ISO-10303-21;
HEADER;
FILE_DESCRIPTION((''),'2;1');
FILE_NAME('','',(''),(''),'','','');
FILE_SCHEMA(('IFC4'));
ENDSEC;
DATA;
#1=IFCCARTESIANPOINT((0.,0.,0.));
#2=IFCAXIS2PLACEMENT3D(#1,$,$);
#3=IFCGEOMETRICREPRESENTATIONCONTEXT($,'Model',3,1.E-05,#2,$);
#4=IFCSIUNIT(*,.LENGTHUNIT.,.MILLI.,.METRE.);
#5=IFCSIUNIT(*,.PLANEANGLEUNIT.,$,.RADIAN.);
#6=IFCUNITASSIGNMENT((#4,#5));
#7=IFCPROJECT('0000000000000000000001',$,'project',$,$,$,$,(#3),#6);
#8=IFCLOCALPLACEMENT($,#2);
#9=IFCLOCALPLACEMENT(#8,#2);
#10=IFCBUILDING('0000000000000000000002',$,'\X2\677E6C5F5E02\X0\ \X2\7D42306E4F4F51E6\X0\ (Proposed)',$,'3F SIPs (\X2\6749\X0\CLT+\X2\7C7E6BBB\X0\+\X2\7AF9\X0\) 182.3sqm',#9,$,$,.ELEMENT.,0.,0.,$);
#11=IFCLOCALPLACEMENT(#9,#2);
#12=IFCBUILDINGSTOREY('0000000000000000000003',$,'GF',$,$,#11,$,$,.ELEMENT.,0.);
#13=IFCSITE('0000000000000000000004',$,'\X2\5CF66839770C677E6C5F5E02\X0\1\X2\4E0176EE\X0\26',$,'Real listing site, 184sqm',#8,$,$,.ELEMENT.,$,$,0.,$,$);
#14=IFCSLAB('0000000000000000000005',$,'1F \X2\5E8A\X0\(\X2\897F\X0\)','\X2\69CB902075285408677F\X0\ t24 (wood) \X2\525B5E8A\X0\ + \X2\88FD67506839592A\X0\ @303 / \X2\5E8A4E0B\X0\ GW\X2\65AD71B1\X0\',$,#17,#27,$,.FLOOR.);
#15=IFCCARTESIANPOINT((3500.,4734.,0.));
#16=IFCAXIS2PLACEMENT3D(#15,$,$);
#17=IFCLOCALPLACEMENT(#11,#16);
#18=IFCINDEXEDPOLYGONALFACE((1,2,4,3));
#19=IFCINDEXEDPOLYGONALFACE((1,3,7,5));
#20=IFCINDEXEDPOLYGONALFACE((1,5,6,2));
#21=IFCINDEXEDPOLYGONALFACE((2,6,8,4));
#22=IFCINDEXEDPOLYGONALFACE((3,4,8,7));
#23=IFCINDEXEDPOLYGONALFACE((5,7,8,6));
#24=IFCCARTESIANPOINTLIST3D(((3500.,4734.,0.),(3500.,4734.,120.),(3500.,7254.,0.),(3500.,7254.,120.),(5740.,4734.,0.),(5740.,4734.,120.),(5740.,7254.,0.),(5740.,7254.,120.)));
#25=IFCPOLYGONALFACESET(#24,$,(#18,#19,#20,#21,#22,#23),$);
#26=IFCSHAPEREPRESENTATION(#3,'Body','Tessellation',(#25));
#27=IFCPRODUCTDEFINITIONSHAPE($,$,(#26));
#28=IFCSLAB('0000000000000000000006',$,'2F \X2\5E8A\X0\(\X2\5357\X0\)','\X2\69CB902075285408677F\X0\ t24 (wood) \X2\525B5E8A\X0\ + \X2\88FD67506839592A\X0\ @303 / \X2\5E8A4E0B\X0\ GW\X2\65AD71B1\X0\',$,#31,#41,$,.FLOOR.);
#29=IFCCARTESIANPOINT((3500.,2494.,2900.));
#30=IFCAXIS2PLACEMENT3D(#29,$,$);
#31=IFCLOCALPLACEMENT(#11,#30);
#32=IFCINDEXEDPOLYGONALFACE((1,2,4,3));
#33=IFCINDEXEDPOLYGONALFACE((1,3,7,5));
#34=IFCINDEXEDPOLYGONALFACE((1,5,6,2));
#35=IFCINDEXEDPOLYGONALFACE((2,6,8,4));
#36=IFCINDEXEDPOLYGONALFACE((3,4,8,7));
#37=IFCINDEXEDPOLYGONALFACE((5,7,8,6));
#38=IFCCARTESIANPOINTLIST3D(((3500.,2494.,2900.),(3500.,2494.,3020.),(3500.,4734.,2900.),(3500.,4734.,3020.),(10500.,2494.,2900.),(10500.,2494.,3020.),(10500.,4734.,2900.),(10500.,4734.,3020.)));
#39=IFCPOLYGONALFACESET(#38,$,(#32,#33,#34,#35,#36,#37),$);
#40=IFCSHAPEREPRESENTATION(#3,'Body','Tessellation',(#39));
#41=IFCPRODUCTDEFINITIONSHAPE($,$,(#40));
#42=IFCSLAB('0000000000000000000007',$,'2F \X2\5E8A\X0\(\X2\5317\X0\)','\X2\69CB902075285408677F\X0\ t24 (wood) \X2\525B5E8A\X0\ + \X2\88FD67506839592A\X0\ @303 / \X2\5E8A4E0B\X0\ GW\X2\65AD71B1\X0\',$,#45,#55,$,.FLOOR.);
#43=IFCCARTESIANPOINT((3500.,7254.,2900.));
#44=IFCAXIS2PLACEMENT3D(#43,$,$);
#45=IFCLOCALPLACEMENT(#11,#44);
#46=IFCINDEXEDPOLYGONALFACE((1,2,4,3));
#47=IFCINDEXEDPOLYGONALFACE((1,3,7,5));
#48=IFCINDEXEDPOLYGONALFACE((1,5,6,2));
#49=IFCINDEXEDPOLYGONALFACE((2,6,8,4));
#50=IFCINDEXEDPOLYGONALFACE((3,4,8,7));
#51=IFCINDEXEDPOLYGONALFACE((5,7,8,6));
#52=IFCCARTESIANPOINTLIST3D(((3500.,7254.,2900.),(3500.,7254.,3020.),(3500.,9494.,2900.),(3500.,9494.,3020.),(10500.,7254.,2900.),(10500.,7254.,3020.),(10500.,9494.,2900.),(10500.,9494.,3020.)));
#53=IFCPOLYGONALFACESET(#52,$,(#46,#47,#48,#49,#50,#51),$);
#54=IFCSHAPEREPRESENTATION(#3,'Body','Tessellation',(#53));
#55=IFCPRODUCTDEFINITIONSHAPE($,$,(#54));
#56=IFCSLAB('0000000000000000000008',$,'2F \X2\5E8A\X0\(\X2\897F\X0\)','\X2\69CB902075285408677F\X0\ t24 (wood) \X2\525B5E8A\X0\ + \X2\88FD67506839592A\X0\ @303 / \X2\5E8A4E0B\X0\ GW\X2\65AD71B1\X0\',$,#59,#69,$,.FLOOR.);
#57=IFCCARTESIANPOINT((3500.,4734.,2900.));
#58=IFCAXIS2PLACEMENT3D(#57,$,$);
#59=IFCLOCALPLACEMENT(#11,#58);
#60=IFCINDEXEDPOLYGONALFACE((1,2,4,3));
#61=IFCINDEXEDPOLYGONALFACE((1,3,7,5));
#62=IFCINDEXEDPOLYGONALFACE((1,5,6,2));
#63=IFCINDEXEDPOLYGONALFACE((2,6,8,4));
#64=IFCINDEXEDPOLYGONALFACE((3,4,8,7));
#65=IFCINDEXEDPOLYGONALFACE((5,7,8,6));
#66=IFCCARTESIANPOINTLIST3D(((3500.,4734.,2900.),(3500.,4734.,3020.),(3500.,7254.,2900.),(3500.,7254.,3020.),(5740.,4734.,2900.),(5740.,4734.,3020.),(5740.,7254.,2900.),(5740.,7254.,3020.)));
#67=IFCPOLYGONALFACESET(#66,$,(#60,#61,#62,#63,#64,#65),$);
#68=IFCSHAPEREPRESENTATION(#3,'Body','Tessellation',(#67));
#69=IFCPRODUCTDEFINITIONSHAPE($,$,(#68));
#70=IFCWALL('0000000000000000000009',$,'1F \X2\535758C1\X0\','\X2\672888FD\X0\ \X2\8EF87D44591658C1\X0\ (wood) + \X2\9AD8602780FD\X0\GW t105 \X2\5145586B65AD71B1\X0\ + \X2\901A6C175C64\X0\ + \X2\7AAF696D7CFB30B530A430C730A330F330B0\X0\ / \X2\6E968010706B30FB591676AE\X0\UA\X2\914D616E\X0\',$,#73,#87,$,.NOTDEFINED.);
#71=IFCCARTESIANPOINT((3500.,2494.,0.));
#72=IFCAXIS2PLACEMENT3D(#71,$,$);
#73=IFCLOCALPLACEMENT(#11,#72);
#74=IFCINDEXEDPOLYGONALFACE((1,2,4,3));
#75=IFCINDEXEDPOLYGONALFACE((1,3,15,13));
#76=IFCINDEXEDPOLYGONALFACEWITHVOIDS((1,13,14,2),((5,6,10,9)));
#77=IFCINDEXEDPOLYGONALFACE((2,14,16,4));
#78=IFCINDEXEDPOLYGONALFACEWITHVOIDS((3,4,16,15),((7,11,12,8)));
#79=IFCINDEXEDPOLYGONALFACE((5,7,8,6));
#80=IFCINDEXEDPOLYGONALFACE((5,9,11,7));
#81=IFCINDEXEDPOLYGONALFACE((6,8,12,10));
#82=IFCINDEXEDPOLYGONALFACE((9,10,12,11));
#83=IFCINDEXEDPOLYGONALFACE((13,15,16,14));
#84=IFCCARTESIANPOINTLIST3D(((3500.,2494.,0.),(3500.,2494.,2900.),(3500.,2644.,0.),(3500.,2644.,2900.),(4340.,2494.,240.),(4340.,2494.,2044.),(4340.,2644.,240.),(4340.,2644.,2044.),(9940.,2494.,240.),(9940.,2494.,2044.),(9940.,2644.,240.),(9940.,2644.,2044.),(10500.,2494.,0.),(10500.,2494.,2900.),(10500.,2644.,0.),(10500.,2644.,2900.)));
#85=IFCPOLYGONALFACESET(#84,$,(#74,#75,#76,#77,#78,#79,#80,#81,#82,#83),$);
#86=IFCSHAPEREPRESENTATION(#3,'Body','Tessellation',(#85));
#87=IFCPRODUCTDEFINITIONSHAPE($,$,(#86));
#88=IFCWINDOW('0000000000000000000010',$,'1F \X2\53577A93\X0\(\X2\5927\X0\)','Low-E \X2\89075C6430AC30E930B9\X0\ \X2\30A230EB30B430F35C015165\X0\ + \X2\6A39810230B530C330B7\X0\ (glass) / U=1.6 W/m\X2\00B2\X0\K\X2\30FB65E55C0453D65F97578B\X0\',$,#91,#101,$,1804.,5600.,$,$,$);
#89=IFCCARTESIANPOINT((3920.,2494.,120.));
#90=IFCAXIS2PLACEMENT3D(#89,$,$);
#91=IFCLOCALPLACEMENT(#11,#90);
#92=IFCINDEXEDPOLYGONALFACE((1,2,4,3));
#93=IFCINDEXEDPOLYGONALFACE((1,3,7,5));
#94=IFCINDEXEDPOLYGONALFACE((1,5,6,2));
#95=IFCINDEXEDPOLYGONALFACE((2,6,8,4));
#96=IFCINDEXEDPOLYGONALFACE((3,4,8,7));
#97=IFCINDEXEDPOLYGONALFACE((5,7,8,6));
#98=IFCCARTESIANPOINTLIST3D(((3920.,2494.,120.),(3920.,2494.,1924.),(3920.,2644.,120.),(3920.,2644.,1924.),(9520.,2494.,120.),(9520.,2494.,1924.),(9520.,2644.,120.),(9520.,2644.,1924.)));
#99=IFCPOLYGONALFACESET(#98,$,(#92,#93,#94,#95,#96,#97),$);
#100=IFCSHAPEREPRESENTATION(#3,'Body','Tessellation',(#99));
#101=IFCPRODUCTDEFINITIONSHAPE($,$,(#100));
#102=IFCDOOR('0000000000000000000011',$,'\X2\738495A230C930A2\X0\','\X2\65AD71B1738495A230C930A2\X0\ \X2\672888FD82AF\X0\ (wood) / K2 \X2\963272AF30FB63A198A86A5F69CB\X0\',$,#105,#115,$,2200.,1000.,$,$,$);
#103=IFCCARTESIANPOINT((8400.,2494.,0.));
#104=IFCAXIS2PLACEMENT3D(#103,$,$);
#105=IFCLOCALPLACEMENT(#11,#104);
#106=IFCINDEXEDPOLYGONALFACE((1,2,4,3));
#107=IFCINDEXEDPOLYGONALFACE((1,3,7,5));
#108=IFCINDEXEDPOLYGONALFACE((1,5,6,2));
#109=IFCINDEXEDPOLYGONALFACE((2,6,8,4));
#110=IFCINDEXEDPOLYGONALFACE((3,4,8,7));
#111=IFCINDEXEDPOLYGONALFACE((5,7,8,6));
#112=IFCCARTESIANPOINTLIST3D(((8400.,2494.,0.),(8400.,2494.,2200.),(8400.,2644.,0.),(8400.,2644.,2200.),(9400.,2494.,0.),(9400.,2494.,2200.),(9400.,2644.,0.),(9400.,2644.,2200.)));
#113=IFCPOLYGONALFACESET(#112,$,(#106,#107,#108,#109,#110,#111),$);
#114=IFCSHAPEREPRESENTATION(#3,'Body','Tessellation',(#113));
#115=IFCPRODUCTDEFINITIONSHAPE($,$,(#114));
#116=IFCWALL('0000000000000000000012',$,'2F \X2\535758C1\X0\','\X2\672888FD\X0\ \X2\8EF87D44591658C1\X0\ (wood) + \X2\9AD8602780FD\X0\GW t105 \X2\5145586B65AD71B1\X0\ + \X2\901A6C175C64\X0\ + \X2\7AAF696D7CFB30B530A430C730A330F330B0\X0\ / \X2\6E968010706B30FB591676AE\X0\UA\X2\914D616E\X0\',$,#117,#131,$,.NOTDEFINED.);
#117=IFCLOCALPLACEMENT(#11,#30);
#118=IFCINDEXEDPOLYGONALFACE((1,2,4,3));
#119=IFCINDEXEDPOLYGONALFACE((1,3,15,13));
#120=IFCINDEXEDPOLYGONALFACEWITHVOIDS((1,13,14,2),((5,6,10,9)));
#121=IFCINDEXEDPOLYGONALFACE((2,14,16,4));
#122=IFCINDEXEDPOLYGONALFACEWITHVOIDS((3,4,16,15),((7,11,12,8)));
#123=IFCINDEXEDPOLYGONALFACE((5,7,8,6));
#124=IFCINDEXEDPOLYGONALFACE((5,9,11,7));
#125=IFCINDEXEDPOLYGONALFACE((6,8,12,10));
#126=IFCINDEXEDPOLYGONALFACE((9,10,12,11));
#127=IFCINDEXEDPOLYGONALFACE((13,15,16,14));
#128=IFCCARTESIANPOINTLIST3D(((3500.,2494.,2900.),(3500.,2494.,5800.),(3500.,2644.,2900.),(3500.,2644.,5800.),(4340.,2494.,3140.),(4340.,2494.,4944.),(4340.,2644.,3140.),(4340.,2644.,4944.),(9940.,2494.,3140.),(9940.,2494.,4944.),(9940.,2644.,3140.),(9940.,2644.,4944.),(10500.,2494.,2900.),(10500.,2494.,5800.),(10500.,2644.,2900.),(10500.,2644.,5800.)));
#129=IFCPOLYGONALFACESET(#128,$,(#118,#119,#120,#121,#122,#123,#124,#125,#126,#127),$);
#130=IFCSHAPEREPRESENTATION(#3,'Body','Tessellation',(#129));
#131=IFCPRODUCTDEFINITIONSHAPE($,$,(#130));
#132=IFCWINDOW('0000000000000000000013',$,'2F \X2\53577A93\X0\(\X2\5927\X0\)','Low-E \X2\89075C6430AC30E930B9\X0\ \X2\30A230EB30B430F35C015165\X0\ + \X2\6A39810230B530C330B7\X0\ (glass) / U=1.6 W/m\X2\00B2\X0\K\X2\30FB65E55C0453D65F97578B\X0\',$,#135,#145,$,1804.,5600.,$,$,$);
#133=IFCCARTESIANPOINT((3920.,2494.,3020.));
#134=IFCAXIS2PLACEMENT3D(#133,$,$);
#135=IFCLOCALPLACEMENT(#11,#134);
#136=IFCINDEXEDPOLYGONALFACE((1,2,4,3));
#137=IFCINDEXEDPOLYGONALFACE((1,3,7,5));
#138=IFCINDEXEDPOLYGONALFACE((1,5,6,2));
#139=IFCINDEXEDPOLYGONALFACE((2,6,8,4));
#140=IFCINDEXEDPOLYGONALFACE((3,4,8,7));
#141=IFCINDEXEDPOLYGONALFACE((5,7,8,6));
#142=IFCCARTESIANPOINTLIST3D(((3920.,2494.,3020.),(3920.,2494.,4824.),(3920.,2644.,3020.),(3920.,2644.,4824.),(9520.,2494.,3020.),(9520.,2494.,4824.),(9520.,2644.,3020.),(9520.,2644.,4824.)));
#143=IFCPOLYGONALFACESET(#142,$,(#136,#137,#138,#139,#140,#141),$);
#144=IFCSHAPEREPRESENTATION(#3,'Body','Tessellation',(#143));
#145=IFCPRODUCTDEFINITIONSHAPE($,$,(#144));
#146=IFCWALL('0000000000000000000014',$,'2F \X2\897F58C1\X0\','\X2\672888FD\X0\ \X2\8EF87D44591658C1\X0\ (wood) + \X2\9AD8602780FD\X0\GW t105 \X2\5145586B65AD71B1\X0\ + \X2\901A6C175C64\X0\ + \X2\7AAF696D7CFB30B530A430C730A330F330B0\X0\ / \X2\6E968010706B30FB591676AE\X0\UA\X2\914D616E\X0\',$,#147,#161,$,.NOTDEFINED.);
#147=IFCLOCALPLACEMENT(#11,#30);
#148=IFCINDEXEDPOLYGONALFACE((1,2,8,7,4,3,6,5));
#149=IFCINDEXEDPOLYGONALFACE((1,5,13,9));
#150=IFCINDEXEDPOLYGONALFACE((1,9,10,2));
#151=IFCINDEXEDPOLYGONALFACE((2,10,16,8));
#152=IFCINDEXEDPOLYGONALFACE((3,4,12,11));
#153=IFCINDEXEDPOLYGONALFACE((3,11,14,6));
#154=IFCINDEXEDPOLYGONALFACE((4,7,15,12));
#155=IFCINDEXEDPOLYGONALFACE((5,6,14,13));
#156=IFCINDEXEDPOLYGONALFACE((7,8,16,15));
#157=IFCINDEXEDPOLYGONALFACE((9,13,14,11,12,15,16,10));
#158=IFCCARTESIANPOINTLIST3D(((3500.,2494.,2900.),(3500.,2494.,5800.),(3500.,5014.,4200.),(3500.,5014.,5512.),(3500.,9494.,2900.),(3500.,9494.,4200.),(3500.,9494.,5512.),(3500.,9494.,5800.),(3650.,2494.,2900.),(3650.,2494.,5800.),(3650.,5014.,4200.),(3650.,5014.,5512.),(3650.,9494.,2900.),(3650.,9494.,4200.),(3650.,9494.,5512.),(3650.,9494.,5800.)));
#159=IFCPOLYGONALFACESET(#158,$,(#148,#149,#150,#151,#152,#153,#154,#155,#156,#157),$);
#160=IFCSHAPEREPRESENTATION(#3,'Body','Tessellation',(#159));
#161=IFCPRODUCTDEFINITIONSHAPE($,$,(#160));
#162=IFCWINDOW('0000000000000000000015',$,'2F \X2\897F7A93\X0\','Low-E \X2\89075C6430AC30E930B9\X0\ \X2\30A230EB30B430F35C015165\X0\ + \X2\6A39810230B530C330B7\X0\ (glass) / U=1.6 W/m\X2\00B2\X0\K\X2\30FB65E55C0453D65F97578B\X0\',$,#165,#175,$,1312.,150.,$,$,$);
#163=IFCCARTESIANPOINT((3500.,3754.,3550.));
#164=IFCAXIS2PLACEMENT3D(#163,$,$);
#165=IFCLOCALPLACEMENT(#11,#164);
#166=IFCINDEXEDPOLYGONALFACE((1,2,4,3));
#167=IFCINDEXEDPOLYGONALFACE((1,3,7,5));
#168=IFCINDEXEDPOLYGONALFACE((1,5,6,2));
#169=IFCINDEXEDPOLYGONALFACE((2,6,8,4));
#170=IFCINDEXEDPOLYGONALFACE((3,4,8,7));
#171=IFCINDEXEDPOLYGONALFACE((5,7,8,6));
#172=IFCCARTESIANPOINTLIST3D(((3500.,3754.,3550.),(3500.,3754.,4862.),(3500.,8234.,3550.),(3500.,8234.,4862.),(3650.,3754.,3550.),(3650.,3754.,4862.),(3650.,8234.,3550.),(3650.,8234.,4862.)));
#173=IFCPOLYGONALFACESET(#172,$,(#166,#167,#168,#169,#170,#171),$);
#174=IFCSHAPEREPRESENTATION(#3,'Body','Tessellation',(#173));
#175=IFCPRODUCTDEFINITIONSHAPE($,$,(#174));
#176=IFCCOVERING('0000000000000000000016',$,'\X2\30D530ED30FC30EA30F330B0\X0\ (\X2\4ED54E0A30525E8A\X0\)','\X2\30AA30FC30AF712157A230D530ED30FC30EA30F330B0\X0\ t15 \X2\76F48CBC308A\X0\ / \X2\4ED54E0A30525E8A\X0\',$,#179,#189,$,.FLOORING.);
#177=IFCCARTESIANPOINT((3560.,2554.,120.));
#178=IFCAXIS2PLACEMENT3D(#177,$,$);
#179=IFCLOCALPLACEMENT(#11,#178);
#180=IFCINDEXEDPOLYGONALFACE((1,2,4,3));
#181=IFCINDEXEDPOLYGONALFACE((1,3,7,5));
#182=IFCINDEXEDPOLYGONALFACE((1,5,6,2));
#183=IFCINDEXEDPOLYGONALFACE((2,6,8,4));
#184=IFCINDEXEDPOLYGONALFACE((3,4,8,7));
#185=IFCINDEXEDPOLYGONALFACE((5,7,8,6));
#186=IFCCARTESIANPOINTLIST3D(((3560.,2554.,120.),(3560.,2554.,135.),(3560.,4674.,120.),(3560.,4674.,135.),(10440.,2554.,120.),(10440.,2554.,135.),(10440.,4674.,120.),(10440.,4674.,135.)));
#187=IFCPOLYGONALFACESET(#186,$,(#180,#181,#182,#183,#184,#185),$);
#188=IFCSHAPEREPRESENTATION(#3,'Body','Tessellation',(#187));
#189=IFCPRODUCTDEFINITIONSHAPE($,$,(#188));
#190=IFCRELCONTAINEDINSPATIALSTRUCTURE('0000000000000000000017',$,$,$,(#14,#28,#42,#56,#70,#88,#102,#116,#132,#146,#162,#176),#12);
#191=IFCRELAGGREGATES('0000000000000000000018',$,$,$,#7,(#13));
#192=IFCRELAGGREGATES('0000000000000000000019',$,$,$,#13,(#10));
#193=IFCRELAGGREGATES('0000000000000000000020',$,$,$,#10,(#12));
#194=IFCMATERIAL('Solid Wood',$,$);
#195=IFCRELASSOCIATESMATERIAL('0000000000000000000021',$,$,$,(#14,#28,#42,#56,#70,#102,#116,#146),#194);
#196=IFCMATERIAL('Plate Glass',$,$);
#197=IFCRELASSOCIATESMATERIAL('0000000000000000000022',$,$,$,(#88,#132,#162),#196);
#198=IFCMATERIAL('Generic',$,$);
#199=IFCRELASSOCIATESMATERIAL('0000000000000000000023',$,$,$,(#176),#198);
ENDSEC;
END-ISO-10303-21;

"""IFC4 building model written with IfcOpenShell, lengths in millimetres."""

from ifc_helpers import new_model, si_unit, frame, frame_2d, origin, place, context, project, spatial, rectangle, extrude, material, element, fill, save


model = new_model("IFC4")

# Units and contexts
model_context = context("Model", 3, precision=1e-05, world=origin())
ifc_project = project(units=[si_unit("LENGTHUNIT", "METRE", prefix="MILLI"), si_unit("PLANEANGLEUNIT", "RADIAN")], contexts=[model_context])

# Site, building, storey
site_placement = place(None, origin())
site = spatial("IfcSite", under=ifc_project, at=site_placement, Name="島根県松江市1丁目26", ObjectType="Real listing site, 184sqm", CompositionType="ELEMENT", RefElevation=0.0)
building_placement = place(site_placement, origin())
building = spatial("IfcBuilding", under=site, at=building_placement, Name="松江市 終の住処 (Proposed)", ObjectType="3F SIPs (杉CLT+籾殻+竹) 182.3sqm", CompositionType="ELEMENT", ElevationOfRefHeight=0.0, ElevationOfTerrain=0.0)
storey_placement = place(building_placement, origin())
storey = spatial("IfcBuildingStorey", under=building, at=storey_placement, Name="GF", CompositionType="ELEMENT", Elevation=0.0)

# Slabs
ifc_material_1 = material(Name="Solid Wood")
slab_1_placement = place(storey_placement, frame((3500.0, 4734.0, 0.0)))
element("IfcSlab", 1, at=slab_1_placement, inside=storey, material=ifc_material_1, Name="1F 床(西)", Description="構造用合板 t24 (wood) 剛床 + 製材根太 @303 / 床下 GW断熱", PredefinedType="FLOOR", context=model_context, shape_type="SweptSolid", body=[
    extrude(rectangle(XDim=2240.0, YDim=2520.0, at=frame_2d((1120.0, 1260.0))), frame((3500.0, 4734.0, 0.0)), (0.0, 0.0, 1.0), 120.0),
])
slab_2_placement = place(storey_placement, frame((3500.0, 2494.0, 2900.0)))
element("IfcSlab", 2, at=slab_2_placement, inside=storey, material=ifc_material_1, Name="2F 床(南)", Description="構造用合板 t24 (wood) 剛床 + 製材根太 @303 / 床下 GW断熱", PredefinedType="FLOOR", context=model_context, shape_type="SweptSolid", body=[
    extrude(rectangle(XDim=7000.0, YDim=2240.0, at=frame_2d((3500.0, 1120.0))), frame((3500.0, 2494.0, 2900.0)), (0.0, 0.0, 1.0), 120.0),
])
slab_3_placement = place(storey_placement, frame((3500.0, 7254.0, 2900.0)))
element("IfcSlab", 3, at=slab_3_placement, inside=storey, material=ifc_material_1, Name="2F 床(北)", Description="構造用合板 t24 (wood) 剛床 + 製材根太 @303 / 床下 GW断熱", PredefinedType="FLOOR", context=model_context, shape_type="SweptSolid", body=[
    extrude(rectangle(XDim=7000.0, YDim=2240.0, at=frame_2d((3500.0, 1120.0))), frame((3500.0, 7254.0, 2900.0)), (0.0, 0.0, 1.0), 120.0),
])
slab_4_placement = place(storey_placement, frame((3500.0, 4734.0, 2900.0)))
element("IfcSlab", 4, at=slab_4_placement, inside=storey, material=ifc_material_1, Name="2F 床(西)", Description="構造用合板 t24 (wood) 剛床 + 製材根太 @303 / 床下 GW断熱", PredefinedType="FLOOR", context=model_context, shape_type="SweptSolid", body=[
    extrude(rectangle(XDim=2240.0, YDim=2520.0, at=frame_2d((1120.0, 1260.0))), frame((3500.0, 4734.0, 2900.0)), (0.0, 0.0, 1.0), 120.0),
])

# Wall, openings, window, door
wall_1_placement = place(storey_placement, frame((3500.0, 2494.0, 0.0)))
wall_1 = element("IfcWall", 5, at=wall_1_placement, inside=storey, material=ifc_material_1, Name="1F 南壁", Description="木製 軸組外壁 (wood) + 高性能GW t105 充填断熱 + 通気層 + 窯業系サイディング / 準耐火・外皮UA配慮", PredefinedType="NOTDEFINED", context=model_context, shape_type="SweptSolid", body=[
    extrude(rectangle(XDim=7000.0, YDim=150.0, at=frame_2d((3500.0, 75.0))), frame((3500.0, 2494.0, 0.0)), (0.0, 0.0, 1.0), 2900.0),
])
opening_1_placement = place(storey_placement, frame((3920.0, 2494.0, 120.0)))
opening_1 = element("IfcOpeningElement", 6, at=opening_1_placement, cuts=wall_1, PredefinedType="NOTDEFINED", context=model_context, shape_type="SweptSolid", body=[
    extrude(rectangle(XDim=5600.0, YDim=150.0, at=frame_2d((2800.0, 75.0))), frame((3920.0, 2494.0, 120.0)), (0.0, 0.0, 1.0), 1804.0),
])
opening_2_placement = place(storey_placement, frame((8400.0, 2494.0, 0.0)))
opening_2 = element("IfcOpeningElement", 7, at=opening_2_placement, cuts=wall_1, PredefinedType="NOTDEFINED", context=model_context, shape_type="SweptSolid", body=[
    extrude(rectangle(XDim=1000.0, YDim=150.0, at=frame_2d((500.0, 75.0))), frame((8400.0, 2494.0, 0.0)), (0.0, 0.0, 1.0), 2200.0),
])
ifc_material_2 = material(Name="Plate Glass")
window_1_placement = place(storey_placement, frame((3920.0, 2494.0, 120.0)))
window_1 = element("IfcWindow", 8, at=window_1_placement, inside=storey, material=ifc_material_2, Name="1F 南窓(大)", Description="Low-E 複層ガラス アルゴン封入 + 樹脂サッシ (glass) / U=1.6 W/m²K・日射取得型", OverallHeight=1804.0, OverallWidth=5600.0, context=model_context, shape_type="SweptSolid", body=[
    extrude(rectangle(XDim=5600.0, YDim=150.0, at=frame_2d((2800.0, 75.0))), frame((3920.0, 2494.0, 120.0)), (0.0, 0.0, 1.0), 1804.0),
])
fill(opening_1, window_1)
door_placement = place(storey_placement, frame((8400.0, 2494.0, 0.0)))
door = element("IfcDoor", 9, at=door_placement, inside=storey, material=ifc_material_1, Name="玄関ドア", Description="断熱玄関ドア 木製芯 (wood) / K2 防犯・採風機構", OverallHeight=2200.0, OverallWidth=1000.0, context=model_context, shape_type="SweptSolid", body=[
    extrude(rectangle(XDim=1000.0, YDim=150.0, at=frame_2d((500.0, 75.0))), frame((8400.0, 2494.0, 0.0)), (0.0, 0.0, 1.0), 2200.0),
])
fill(opening_2, door)

# Wall, opening, window
wall_2_placement = place(storey_placement, frame((3500.0, 2494.0, 2900.0)))
wall_2 = element("IfcWall", 10, at=wall_2_placement, inside=storey, material=ifc_material_1, Name="2F 南壁", Description="木製 軸組外壁 (wood) + 高性能GW t105 充填断熱 + 通気層 + 窯業系サイディング / 準耐火・外皮UA配慮", PredefinedType="NOTDEFINED", context=model_context, shape_type="SweptSolid", body=[
    extrude(rectangle(XDim=7000.0, YDim=150.0, at=frame_2d((3500.0, 75.0))), frame((3500.0, 2494.0, 2900.0)), (0.0, 0.0, 1.0), 2900.0),
])
opening_3_placement = place(storey_placement, frame((3920.0, 2494.0, 3020.0)))
opening_3 = element("IfcOpeningElement", 11, at=opening_3_placement, cuts=wall_2, PredefinedType="NOTDEFINED", context=model_context, shape_type="SweptSolid", body=[
    extrude(rectangle(XDim=5600.0, YDim=150.0, at=frame_2d((2800.0, 75.0))), frame((3920.0, 2494.0, 3020.0)), (0.0, 0.0, 1.0), 1804.0),
])
window_2_placement = place(storey_placement, frame((3920.0, 2494.0, 3020.0)))
window_2 = element("IfcWindow", 12, at=window_2_placement, inside=storey, material=ifc_material_2, Name="2F 南窓(大)", Description="Low-E 複層ガラス アルゴン封入 + 樹脂サッシ (glass) / U=1.6 W/m²K・日射取得型", OverallHeight=1804.0, OverallWidth=5600.0, context=model_context, shape_type="SweptSolid", body=[
    extrude(rectangle(XDim=5600.0, YDim=150.0, at=frame_2d((2800.0, 75.0))), frame((3920.0, 2494.0, 3020.0)), (0.0, 0.0, 1.0), 1804.0),
])
fill(opening_3, window_2)

# Wall, opening, window
wall_3_placement = place(storey_placement, frame((3500.0, 2494.0, 2900.0)))
wall_3 = element("IfcWall", 13, at=wall_3_placement, inside=storey, material=ifc_material_1, Name="2F 西壁", Description="木製 軸組外壁 (wood) + 高性能GW t105 充填断熱 + 通気層 + 窯業系サイディング / 準耐火・外皮UA配慮", PredefinedType="NOTDEFINED", context=model_context, shape_type="SweptSolid", body=[
    extrude(rectangle(XDim=150.0, YDim=7000.0, at=frame_2d((75.0, 3500.0))), frame((3500.0, 2494.0, 2900.0)), (0.0, 0.0, 1.0), 2900.0),
])
opening_4_placement = place(storey_placement, frame((3500.0, 3754.0, 3550.0)))
opening_4 = element("IfcOpeningElement", 14, at=opening_4_placement, cuts=wall_3, PredefinedType="NOTDEFINED", context=model_context, shape_type="SweptSolid", body=[
    extrude(rectangle(XDim=150.0, YDim=4480.0, at=frame_2d((75.0, 2240.0))), frame((3500.0, 3754.0, 3550.0)), (0.0, 0.0, 1.0), 1312.0),
])
window_3_placement = place(storey_placement, frame((3500.0, 3754.0, 3550.0)))
window_3 = element("IfcWindow", 15, at=window_3_placement, inside=storey, material=ifc_material_2, Name="2F 西窓", Description="Low-E 複層ガラス アルゴン封入 + 樹脂サッシ (glass) / U=1.6 W/m²K・日射取得型", OverallHeight=1312.0, OverallWidth=150.0, context=model_context, shape_type="SweptSolid", body=[
    extrude(rectangle(XDim=150.0, YDim=4480.0, at=frame_2d((75.0, 2240.0))), frame((3500.0, 3754.0, 3550.0)), (0.0, 0.0, 1.0), 1312.0),
])
fill(opening_4, window_3)

# Covering
ifc_material_3 = material(Name="Generic")
covering_1_placement = place(storey_placement, frame((3560.0, 2554.0, 120.0)))
element("IfcCovering", 16, at=covering_1_placement, inside=storey, material=ifc_material_3, Name="フローリング (仕上げ床)", Description="オーク無垢フローリング t15 直貼り / 仕上げ床", PredefinedType="FLOORING", context=model_context, shape_type="SweptSolid", body=[
    extrude(rectangle(XDim=6880.0, YDim=2120.0, at=frame_2d((3440.0, 1060.0))), frame((3560.0, 2554.0, 120.0)), (0.0, 0.0, 1.0), 15.0),
])

save(model, "model.ifc")
